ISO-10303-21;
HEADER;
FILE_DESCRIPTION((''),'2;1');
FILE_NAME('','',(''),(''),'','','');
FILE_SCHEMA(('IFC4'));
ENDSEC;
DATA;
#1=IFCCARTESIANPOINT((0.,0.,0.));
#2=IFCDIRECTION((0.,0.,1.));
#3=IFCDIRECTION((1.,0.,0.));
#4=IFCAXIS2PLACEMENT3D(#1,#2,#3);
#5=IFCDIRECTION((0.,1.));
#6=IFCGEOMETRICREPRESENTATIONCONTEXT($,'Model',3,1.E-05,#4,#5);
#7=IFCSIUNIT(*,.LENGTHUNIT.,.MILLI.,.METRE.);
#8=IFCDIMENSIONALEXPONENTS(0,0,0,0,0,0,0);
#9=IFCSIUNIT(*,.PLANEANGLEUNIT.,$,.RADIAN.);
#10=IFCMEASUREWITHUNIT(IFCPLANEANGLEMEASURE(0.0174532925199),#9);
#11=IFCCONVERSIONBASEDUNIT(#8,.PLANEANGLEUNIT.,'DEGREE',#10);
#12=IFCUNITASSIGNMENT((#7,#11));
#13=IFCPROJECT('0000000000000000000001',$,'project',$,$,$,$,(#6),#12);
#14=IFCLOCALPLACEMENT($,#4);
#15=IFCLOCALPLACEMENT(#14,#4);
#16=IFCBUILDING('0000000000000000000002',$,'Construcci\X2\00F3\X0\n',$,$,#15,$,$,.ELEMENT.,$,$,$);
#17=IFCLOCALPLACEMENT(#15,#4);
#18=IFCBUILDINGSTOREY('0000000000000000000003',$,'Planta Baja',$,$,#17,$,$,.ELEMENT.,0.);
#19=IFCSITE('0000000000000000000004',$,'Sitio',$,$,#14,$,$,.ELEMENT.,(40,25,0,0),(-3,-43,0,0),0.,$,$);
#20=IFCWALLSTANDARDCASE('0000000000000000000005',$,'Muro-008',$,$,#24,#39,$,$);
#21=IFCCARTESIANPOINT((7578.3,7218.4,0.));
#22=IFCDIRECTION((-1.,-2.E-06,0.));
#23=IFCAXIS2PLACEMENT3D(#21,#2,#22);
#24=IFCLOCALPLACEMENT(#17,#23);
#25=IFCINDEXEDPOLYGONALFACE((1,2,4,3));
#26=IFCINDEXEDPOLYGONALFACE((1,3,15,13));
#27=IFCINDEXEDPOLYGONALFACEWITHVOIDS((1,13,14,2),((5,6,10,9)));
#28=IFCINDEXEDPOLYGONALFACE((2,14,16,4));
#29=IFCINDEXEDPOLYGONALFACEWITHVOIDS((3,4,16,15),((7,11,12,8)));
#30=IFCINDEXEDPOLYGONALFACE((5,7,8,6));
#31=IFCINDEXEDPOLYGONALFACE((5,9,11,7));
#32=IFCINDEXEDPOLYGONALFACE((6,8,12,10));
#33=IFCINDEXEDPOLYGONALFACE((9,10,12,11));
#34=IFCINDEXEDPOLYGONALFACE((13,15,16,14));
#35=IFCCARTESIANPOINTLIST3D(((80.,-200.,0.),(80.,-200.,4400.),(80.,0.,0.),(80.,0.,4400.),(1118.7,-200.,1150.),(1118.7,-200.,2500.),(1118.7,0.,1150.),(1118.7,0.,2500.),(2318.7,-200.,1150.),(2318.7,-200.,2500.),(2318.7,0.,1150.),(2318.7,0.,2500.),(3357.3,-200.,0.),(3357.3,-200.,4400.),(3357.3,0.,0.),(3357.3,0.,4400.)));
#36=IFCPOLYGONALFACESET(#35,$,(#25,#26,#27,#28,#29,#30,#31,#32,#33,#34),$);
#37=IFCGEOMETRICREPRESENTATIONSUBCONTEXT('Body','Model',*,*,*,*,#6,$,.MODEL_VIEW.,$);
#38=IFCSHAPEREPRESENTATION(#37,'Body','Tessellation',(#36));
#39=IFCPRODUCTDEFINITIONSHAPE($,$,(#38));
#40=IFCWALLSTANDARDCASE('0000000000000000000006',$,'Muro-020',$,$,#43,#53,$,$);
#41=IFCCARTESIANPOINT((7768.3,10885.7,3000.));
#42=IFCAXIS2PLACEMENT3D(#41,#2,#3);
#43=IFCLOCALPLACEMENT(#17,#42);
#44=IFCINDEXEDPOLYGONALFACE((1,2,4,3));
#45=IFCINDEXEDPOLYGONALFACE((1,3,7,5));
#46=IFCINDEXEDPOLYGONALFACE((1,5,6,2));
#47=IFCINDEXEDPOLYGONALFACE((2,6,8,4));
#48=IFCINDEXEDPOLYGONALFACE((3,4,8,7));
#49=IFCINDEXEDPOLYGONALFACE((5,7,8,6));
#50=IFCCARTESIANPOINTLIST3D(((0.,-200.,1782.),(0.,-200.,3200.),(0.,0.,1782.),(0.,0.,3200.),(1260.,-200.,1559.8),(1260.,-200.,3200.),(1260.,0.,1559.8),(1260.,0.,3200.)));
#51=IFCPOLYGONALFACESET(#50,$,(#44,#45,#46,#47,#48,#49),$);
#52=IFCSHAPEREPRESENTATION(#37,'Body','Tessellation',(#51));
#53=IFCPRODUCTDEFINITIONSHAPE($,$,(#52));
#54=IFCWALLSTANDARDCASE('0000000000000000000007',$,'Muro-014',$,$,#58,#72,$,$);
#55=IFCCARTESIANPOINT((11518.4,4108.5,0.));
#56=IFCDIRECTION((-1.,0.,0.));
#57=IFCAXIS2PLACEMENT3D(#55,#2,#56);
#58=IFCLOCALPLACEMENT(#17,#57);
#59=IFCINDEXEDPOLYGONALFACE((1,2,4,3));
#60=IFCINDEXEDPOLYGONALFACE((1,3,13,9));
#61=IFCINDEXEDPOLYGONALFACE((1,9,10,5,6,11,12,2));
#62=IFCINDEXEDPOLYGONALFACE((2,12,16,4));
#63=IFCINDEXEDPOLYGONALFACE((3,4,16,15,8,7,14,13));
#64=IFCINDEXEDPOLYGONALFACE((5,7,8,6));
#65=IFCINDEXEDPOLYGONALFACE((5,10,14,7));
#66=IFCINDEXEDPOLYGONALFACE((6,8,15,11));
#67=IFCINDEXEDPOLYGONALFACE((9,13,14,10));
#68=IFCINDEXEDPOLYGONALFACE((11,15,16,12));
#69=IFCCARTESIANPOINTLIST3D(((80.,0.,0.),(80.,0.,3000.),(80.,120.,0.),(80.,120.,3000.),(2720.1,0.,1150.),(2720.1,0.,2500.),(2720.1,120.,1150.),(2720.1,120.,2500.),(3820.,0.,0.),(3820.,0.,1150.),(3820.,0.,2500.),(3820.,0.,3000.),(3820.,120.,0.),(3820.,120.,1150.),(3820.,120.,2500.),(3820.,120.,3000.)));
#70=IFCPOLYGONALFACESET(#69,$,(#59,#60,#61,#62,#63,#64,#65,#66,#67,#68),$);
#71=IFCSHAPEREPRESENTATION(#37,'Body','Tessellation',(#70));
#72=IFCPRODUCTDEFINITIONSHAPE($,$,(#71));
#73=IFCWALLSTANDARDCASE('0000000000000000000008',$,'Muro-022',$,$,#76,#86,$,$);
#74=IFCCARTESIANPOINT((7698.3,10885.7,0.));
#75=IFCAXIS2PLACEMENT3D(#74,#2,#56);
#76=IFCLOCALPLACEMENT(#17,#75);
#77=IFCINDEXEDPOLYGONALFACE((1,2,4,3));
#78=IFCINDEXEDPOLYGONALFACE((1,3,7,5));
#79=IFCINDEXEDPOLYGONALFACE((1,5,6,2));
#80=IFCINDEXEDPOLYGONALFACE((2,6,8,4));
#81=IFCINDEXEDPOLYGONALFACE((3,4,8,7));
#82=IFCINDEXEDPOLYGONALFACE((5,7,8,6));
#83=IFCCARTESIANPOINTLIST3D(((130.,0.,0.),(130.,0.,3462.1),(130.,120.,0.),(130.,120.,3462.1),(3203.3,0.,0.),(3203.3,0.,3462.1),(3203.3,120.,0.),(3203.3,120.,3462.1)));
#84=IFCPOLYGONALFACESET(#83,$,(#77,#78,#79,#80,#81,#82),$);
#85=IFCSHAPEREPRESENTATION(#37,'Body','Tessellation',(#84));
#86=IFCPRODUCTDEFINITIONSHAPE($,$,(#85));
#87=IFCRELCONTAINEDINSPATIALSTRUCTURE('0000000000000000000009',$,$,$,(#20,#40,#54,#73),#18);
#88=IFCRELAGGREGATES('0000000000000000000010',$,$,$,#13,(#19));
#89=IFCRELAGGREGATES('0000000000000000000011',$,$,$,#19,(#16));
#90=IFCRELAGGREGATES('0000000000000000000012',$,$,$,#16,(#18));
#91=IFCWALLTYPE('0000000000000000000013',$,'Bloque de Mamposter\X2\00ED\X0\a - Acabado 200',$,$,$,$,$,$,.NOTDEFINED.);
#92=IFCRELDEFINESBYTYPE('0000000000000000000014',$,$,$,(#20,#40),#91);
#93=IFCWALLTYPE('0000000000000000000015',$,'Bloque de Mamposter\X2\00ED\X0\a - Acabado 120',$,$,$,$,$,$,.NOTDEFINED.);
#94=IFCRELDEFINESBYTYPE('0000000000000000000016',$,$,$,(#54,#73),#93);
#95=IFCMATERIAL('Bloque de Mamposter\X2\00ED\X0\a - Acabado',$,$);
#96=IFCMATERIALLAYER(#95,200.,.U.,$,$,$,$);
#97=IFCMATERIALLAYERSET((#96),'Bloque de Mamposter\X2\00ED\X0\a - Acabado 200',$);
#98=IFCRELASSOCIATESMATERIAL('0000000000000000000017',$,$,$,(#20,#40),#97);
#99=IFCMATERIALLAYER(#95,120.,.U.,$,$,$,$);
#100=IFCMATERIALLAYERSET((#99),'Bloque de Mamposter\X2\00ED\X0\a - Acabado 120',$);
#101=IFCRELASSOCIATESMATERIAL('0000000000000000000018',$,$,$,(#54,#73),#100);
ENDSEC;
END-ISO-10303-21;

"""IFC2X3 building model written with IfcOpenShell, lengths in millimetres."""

from ifc_helpers import new_model, entity, si_unit, converted_unit, direction, frame, origin_with_axes, origin_2d_with_axis, place, context, subcontext, project, spatial, polyline, rectangle, outline, extrude, clip, halfspace, material, layer, layer_set, layer_usage, type_object, element, save


model = new_model("IFC2X3")

# Units and contexts
model_context = context("Model", 3, precision=1e-05, world=origin_with_axes(), true_north=direction((0.0, 1.0)))
body_context = subcontext(model_context, "Body", "Model", "MODEL_VIEW")
ifc_project = project(units=[si_unit("LENGTHUNIT", "METRE", prefix="MILLI"), converted_unit("PLANEANGLEUNIT", "DEGREE", entity("IfcPlaneAngleMeasure", 0.0174532925199), si_unit("PLANEANGLEUNIT", "RADIAN"), dimensions=[0, 0, 0, 0, 0, 0, 0])], contexts=[model_context])

# Site, building, storey
site_placement = place(None, origin_with_axes())
site = spatial("IfcSite", under=ifc_project, at=site_placement, Name="Sitio", CompositionType="ELEMENT", RefLatitude=(40, 25, 0, 0), RefLongitude=(-3, -43, 0, 0), RefElevation=0.0)
building_placement = place(site_placement, origin_with_axes())
building = spatial("IfcBuilding", under=site, at=building_placement, Name="Construcción", CompositionType="ELEMENT")
storey_placement = place(building_placement, origin_with_axes())
storey = spatial("IfcBuildingStorey", under=building, at=storey_placement, Name="Planta Baja", CompositionType="ELEMENT", Elevation=0.0)

# Wall, opening
ifc_material_1 = material(Name="Bloque de Mampostería - Acabado")
ifc_layer_1 = layer(ifc_material_1, 200.0, ventilated="UNKNOWN")
ifc_layer_set_1 = layer_set([ifc_layer_1], Name="Bloque de Mampostería - Acabado 200")
ifc_layer_usage_1 = layer_usage(ifc_layer_set_1, "AXIS2", "POSITIVE", -200.0)
wall_type_1 = type_object("IfcWallType", Name="Bloque de Mampostería - Acabado 200", PredefinedType="NOTDEFINED")
wall_1_placement = place(storey_placement, frame((7578.3, 7218.4, 0.0), z_axis=(0.0, 0.0, 1.0), x_axis=(-1.0, -0.000002, 0.0)))
wall_1 = element("IfcWallStandardCase", 1, at=wall_1_placement, inside=storey, type_object=wall_type_1, material=ifc_layer_usage_1, Name="Muro-008", context=body_context, shape_type="SweptSolid", body=[
    extrude(outline(polyline([(80.0, -200.0), (3357.3, -200.0), (3357.3, 0.0), (80.0, 0.0), (80.0, -200.0)])), origin_with_axes(), (0.0, 0.0, 1.0), 4400.0),
])
opening_1_placement = place(wall_1_placement, frame((1718.7, 0.0, 1150.0), z_axis=(0.0, 0.0, 1.0), x_axis=(1.0, 0.0, 0.0)))
element("IfcOpeningElement", 2, at=opening_1_placement, cuts=wall_1, context=body_context, shape_type="SweptSolid", body=[
    extrude(rectangle(XDim=1200.0, YDim=1350.0, at=origin_2d_with_axis()), frame((0.0, 200.0, 675.0), z_axis=(0.0, -1.0, 0.0), x_axis=(-1.0, 0.0, 0.0)), (0.0, 0.0, 1.0), 600.0),
])

# Wall
ifc_layer_usage_2 = layer_usage(ifc_layer_set_1, "AXIS2", "POSITIVE", -200.0)
wall_2_placement = place(storey_placement, frame((7768.3, 10885.7, 3000.0), z_axis=(0.0, 0.0, 1.0), x_axis=(1.0, 0.0, 0.0)))
element("IfcWallStandardCase", 3, at=wall_2_placement, inside=storey, type_object=wall_type_1, material=ifc_layer_usage_2, Name="Muro-020", context=body_context, shape_type="Clipping", body=[
    clip(extrude(outline(polyline([(0.0, -200.0), (1260.0, -200.0), (1260.0, 0.0), (0.0, 0.0), (0.0, -200.0)])), origin_with_axes(), (0.0, 0.0, 1.0), 3200.0), halfspace(frame((304.7, 0.0, 1728.2), z_axis=(0.173648, 0.0, 0.984808), x_axis=(0.0, -1.0, 0.0)), True)),
])

# Shared definitions
ifc_layer_2 = layer(ifc_material_1, 120.0, ventilated="UNKNOWN")
ifc_layer_set_2 = layer_set([ifc_layer_2], Name="Bloque de Mampostería - Acabado 120")
wall_type_2 = type_object("IfcWallType", Name="Bloque de Mampostería - Acabado 120", PredefinedType="NOTDEFINED")

# Wall, opening
ifc_layer_usage_3 = layer_usage(ifc_layer_set_2, "AXIS2", "POSITIVE", 0.0)
wall_3_placement = place(storey_placement, frame((11518.4, 4108.5, 0.0), z_axis=(0.0, 0.0, 1.0), x_axis=(-1.0, 0.0, 0.0)))
wall_3 = element("IfcWallStandardCase", 4, at=wall_3_placement, inside=storey, type_object=wall_type_2, material=ifc_layer_usage_3, Name="Muro-014", context=body_context, shape_type="SweptSolid", body=[
    extrude(outline(polyline([(80.0, 0.0), (3820.0, 0.0), (3820.0, 120.0), (80.0, 120.0), (80.0, 0.0)])), origin_with_axes(), (0.0, 0.0, 1.0), 3000.0),
])
opening_2_placement = place(wall_3_placement, frame((3320.1, 0.0, 1150.0), z_axis=(0.0, 0.0, 1.0), x_axis=(1.0, 0.0, 0.0)))
element("IfcOpeningElement", 5, at=opening_2_placement, cuts=wall_3, context=body_context, shape_type="SweptSolid", body=[
    extrude(rectangle(XDim=1200.0, YDim=1350.0, at=origin_2d_with_axis()), frame((0.0, 120.0, 675.0), z_axis=(0.0, -1.0, 0.0), x_axis=(-1.0, 0.0, 0.0)), (0.0, 0.0, 1.0), 360.0),
])

# Wall
ifc_layer_usage_4 = layer_usage(ifc_layer_set_2, "AXIS2", "POSITIVE", 0.0)
wall_4_placement = place(storey_placement, frame((7698.3, 10885.7, 0.0), z_axis=(0.0, 0.0, 1.0), x_axis=(-1.0, 0.0, 0.0)))
element("IfcWallStandardCase", 6, at=wall_4_placement, inside=storey, type_object=wall_type_2, material=ifc_layer_usage_4, Name="Muro-022", context=body_context, shape_type="SweptSolid", body=[
    extrude(outline(polyline([(130.0, 0.0), (3203.3, 0.0), (3203.3, 120.0), (130.0, 120.0), (130.0, 0.0)])), origin_with_axes(), (0.0, 0.0, 1.0), 3462.1),
])

save(model, "model.ifc")
